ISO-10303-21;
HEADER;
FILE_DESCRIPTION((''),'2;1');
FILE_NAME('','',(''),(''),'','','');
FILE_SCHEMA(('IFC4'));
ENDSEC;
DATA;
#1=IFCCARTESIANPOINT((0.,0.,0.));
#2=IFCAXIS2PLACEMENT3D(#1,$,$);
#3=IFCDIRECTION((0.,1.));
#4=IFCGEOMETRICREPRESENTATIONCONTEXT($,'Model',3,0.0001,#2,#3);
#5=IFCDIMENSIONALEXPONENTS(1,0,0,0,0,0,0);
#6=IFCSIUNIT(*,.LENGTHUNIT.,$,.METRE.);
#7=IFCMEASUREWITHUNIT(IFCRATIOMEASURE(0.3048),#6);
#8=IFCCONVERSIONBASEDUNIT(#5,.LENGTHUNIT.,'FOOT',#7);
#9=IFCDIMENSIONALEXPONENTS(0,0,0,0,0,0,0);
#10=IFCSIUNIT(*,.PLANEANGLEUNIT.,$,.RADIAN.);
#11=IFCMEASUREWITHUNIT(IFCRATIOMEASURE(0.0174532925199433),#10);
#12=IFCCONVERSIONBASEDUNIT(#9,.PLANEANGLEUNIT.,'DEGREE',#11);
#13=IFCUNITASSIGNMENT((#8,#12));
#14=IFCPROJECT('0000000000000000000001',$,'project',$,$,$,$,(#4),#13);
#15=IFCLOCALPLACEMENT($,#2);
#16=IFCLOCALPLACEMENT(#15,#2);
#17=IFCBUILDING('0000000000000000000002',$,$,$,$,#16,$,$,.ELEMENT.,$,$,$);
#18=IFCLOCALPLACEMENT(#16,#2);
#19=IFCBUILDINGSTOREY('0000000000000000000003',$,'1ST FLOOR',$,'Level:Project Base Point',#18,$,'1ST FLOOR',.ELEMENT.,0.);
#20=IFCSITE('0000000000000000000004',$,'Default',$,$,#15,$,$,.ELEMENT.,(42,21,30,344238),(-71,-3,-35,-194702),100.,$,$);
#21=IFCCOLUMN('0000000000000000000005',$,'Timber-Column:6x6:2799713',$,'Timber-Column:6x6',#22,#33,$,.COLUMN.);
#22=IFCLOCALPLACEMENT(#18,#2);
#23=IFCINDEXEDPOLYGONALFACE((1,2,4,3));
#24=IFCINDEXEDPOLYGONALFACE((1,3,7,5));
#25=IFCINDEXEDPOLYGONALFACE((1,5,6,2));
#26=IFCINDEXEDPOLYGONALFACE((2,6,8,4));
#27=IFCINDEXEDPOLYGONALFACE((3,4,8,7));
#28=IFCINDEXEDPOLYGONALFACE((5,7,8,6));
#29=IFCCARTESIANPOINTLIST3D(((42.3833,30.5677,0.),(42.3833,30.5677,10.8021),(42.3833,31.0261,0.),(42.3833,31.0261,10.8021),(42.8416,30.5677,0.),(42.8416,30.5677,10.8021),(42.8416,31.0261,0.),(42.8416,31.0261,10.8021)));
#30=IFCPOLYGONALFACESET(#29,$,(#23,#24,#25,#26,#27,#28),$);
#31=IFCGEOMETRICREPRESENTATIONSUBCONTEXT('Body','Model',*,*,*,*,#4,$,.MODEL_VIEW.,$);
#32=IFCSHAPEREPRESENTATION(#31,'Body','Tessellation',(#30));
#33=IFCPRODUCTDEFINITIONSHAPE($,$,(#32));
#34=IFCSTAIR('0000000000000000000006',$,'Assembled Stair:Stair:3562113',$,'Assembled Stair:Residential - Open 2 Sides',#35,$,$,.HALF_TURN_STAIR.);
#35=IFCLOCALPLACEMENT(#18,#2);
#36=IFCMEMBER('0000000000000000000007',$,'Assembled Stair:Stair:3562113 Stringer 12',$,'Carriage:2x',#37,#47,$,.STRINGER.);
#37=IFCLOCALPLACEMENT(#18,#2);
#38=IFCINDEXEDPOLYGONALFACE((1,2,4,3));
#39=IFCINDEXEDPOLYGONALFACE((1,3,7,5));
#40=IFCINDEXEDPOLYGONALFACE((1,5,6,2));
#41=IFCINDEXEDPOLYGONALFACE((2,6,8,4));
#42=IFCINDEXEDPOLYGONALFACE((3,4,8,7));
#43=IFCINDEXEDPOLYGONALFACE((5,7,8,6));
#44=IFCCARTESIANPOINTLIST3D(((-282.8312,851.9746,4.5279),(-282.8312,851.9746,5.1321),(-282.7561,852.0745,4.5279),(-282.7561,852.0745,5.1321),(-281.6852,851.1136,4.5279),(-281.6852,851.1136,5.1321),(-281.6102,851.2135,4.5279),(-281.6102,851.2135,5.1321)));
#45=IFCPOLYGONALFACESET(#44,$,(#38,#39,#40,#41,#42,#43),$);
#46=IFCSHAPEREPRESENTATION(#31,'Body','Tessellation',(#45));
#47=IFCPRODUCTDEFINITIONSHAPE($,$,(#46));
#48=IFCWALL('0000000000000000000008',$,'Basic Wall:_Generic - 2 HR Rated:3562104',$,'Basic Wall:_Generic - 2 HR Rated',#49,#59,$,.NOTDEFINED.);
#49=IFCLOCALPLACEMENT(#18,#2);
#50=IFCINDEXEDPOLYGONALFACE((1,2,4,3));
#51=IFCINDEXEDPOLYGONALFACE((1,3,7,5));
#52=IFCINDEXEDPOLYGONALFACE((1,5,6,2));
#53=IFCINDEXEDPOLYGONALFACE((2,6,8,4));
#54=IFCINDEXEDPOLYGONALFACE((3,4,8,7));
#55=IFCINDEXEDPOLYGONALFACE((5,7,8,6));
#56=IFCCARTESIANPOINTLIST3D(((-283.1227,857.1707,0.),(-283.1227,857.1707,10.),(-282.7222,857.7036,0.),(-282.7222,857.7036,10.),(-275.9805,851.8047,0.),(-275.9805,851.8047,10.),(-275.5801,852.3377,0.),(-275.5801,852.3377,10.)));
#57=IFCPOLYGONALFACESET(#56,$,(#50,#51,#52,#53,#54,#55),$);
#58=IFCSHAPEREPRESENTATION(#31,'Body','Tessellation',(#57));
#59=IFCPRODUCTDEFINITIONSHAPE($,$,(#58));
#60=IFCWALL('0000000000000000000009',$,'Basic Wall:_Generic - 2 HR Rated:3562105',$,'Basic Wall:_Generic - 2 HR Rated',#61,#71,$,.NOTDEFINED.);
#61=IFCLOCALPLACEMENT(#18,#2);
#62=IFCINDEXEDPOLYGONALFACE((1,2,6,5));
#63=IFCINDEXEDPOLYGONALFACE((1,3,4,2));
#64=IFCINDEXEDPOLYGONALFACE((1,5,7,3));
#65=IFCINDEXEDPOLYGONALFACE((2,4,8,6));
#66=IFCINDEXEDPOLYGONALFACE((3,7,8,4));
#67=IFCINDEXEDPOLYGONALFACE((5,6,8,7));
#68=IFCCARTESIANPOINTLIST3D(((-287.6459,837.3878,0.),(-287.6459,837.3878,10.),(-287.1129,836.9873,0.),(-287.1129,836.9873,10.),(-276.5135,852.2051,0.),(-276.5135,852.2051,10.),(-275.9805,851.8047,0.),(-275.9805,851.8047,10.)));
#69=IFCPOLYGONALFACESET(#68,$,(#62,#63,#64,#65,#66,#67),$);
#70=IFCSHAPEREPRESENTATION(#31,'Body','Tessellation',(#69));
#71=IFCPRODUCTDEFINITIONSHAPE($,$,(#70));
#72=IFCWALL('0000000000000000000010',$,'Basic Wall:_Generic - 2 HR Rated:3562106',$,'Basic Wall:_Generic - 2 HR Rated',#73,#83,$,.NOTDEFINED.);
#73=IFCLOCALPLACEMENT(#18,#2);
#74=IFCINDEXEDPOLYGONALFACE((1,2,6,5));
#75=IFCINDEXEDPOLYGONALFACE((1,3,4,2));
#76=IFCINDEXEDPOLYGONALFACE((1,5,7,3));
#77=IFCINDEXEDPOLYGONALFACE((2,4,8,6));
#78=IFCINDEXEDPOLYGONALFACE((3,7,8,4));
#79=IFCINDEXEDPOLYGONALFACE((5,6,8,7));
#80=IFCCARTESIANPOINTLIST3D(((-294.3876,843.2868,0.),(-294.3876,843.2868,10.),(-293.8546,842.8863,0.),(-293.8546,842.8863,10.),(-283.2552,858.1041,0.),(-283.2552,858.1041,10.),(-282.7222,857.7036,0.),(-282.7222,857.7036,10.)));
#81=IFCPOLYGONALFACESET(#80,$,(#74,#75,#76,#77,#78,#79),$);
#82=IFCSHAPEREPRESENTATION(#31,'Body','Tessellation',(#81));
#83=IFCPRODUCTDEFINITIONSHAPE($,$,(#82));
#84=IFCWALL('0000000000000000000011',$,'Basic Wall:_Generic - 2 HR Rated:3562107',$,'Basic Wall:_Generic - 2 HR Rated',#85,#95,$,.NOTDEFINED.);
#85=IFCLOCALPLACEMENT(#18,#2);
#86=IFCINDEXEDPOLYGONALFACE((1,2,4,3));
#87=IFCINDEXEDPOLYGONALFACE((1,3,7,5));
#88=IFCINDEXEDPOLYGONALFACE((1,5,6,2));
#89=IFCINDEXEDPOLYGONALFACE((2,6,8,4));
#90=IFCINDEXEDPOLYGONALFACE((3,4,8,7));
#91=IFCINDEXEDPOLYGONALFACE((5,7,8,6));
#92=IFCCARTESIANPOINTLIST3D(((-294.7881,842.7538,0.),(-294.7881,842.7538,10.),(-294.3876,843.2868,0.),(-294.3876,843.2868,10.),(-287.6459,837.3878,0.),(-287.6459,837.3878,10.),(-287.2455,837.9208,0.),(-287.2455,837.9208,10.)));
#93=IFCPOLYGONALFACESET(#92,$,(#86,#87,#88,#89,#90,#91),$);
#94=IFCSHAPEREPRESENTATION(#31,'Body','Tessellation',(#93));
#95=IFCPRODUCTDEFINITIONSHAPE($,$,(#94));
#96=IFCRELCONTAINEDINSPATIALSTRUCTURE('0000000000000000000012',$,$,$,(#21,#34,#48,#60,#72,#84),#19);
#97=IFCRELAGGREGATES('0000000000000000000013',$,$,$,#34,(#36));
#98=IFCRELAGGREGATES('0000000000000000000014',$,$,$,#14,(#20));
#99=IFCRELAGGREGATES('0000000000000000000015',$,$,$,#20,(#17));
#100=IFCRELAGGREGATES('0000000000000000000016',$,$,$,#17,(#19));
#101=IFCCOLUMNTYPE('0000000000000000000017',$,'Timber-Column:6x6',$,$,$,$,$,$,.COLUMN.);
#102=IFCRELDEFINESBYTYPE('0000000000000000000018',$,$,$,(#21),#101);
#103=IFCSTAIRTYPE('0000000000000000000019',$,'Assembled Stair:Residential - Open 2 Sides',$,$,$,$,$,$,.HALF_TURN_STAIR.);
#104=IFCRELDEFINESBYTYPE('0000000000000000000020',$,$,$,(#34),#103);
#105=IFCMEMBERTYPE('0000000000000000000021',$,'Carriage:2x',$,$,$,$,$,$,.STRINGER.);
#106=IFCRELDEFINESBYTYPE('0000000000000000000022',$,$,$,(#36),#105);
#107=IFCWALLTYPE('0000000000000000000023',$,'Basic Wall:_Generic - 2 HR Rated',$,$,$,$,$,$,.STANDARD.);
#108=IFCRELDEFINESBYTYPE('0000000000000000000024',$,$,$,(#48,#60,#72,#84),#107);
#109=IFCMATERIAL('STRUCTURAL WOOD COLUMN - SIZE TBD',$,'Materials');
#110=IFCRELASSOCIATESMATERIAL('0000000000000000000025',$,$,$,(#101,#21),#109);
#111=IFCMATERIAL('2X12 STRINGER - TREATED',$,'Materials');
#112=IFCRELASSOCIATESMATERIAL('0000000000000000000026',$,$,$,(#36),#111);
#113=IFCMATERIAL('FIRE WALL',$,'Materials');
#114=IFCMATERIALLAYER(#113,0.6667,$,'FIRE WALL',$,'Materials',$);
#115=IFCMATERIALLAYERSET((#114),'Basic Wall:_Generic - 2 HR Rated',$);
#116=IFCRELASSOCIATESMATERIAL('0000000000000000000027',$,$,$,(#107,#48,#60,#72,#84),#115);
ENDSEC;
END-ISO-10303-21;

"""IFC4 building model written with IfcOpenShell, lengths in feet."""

from ifc_helpers import new_model, entity, si_unit, converted_unit, direction, frame, frame_2d, origin, origin_2d_with_axis, place, context, subcontext, project, spatial, rectangle, extrude, source, transform, mapped, material, layer, layer_set, layer_usage, material_profile, profile_set, profile_usage, type_object, type_shapes, element, aggregate, save


model = new_model("IFC4")

# Units and contexts
model_context = context("Model", 3, precision=0.0001, world=origin(), true_north=direction((0.0, 1.0)))
body_context = subcontext(model_context, "Body", "Model", "MODEL_VIEW")
ifc_project = project(units=[converted_unit("LENGTHUNIT", "FOOT", entity("IfcRatioMeasure", 0.3048), si_unit("LENGTHUNIT", "METRE"), dimensions=[1, 0, 0, 0, 0, 0, 0]), converted_unit("PLANEANGLEUNIT", "DEGREE", entity("IfcRatioMeasure", 0.0174532925199433), si_unit("PLANEANGLEUNIT", "RADIAN"), dimensions=[0, 0, 0, 0, 0, 0, 0])], contexts=[model_context])

# Site, building, storey
site_placement = place(None, origin())
site = spatial("IfcSite", under=ifc_project, at=site_placement, Name="Default", CompositionType="ELEMENT", RefLatitude=(42, 21, 30, 344238), RefLongitude=(-71, -3, -35, -194702), RefElevation=100.0)
building_placement = place(site_placement, origin())
building = spatial("IfcBuilding", under=site, at=building_placement, CompositionType="ELEMENT")
storey_placement = place(building_placement, origin())
storey = spatial("IfcBuildingStorey", under=building, at=storey_placement, Name="1ST FLOOR", ObjectType="Level:Project Base Point", LongName="1ST FLOOR", CompositionType="ELEMENT", Elevation=0.0)

# Column
ifc_material_1 = material(Name="STRUCTURAL WOOD COLUMN - SIZE TBD", Category="Materials")
ifc_material_profile = material_profile(ifc_material_1, rectangle(XDim=0.4583, YDim=0.4583, at=origin_2d_with_axis()), Name="6x6")
ifc_profile_set = profile_set([ifc_material_profile], Name="6x6")
ifc_profile_usage = profile_usage(ifc_profile_set)
column_type = type_object("IfcColumnType", Name="Timber-Column:6x6", PredefinedType="COLUMN", material=ifc_profile_set)
shared_shape_1 = source(origin(), body_context, "Body", "SweptSolid", [
    extrude(rectangle(XDim=0.4583, YDim=0.4583, at=frame_2d((0.0, 0.0), x_axis=(1.0, 0.0))), frame((0.0, 0.0, 0.0), z_axis=(0.0, 0.0, 1.0), x_axis=(0.0, -1.0, 0.0)), (0.0, 0.0, 1.0), 10.8021),
])
type_shapes(column_type, [shared_shape_1])
column_placement = place(storey_placement, frame((42.6125, 30.7969, 0.0)))
element("IfcColumn", 1, at=column_placement, inside=storey, type_object=column_type, material=ifc_profile_usage, Name="Timber-Column:6x6:2799713", ObjectType="Timber-Column:6x6", PredefinedType="COLUMN", context=body_context, shape_type="MappedRepresentation", body=[
    mapped(shared_shape_1, transform((0.0, 0.0, 0.0), scale=1.0)),
])

# Stair, member
stair_type = type_object("IfcStairType", Name="Assembled Stair:Residential - Open 2 Sides", PredefinedType="HALF_TURN_STAIR")
stair_placement = place(storey_placement, origin())
stair = element("IfcStair", 2, at=stair_placement, inside=storey, type_object=stair_type, Name="Assembled Stair:Stair:3562113", ObjectType="Assembled Stair:Residential - Open 2 Sides", PredefinedType="HALF_TURN_STAIR")
ifc_material_2 = material(Name="2X12 STRINGER - TREATED", Category="Materials")
member_type = type_object("IfcMemberType", Name="Carriage:2x", PredefinedType="STRINGER")
member_1_placement = place(stair_placement, frame((-282.8312, 851.1136, 4.5279)))
member_1 = element("IfcMember", 3, at=member_1_placement, type_object=member_type, material=ifc_material_2, Name="Assembled Stair:Stair:3562113 Stringer 12", ObjectType="Carriage:2x", PredefinedType="STRINGER", context=body_context, shape_type="SweptSolid", body=[
    extrude(rectangle(XDim=0.125, YDim=1.4333, at=frame_2d((0.0, 0.0), x_axis=(1.0, 0.0))), frame((0.6105, 0.4804, 0.0), z_axis=(0.0, 0.0, 1.0), x_axis=(-0.60067, -0.799497, 0.0)), (0.0, 0.0, 1.0), 0.6042),
])

# Walls
ifc_material_3 = material(Name="FIRE WALL", Category="Materials")
ifc_layer = layer(ifc_material_3, 0.6667, Name="FIRE WALL", Category="Materials")
ifc_layer_set = layer_set([ifc_layer], Name="Basic Wall:_Generic - 2 HR Rated")
ifc_layer_usage_1 = layer_usage(ifc_layer_set, "AXIS2", "NEGATIVE", 0.3333)
wall_type = type_object("IfcWallType", Name="Basic Wall:_Generic - 2 HR Rated", PredefinedType="STANDARD", material=ifc_layer_set)
wall_1_placement = place(storey_placement, frame((-282.9225, 857.4372, 0.0), z_axis=(0.0, 0.0, 1.0), x_axis=(0.799497, -0.60067, 0.0)))
element("IfcWall", 4, at=wall_1_placement, inside=storey, type_object=wall_type, material=ifc_layer_usage_1, Name="Basic Wall:_Generic - 2 HR Rated:3562104", ObjectType="Basic Wall:_Generic - 2 HR Rated", PredefinedType="NOTDEFINED", context=body_context, shape_type="SweptSolid", body=[
    extrude(rectangle(XDim=8.9333, YDim=0.6667, at=frame_2d((4.4667, 0.0), x_axis=(-1.0, 0.0))), origin(), (0.0, 0.0, 1.0), 10.0),
])
ifc_layer_usage_2 = layer_usage(ifc_layer_set, "AXIS2", "NEGATIVE", 0.3333)
wall_2_placement = place(storey_placement, frame((-276.247, 852.0049, 0.0), z_axis=(0.0, 0.0, 1.0), x_axis=(-0.60067, -0.799497, 0.0)))
element("IfcWall", 5, at=wall_2_placement, inside=storey, type_object=wall_type, material=ifc_layer_usage_2, Name="Basic Wall:_Generic - 2 HR Rated:3562105", ObjectType="Basic Wall:_Generic - 2 HR Rated", PredefinedType="NOTDEFINED", context=body_context, shape_type="SweptSolid", body=[
    extrude(rectangle(XDim=18.5333, YDim=0.6667, at=frame_2d((9.2667, 0.0), x_axis=(-1.0, 0.0))), origin(), (0.0, 0.0, 1.0), 10.0),
])
ifc_layer_usage_3 = layer_usage(ifc_layer_set, "AXIS2", "NEGATIVE", 0.3333)
wall_3_placement = place(storey_placement, frame((-294.1211, 843.0865, 0.0), z_axis=(0.0, 0.0, 1.0), x_axis=(0.60067, 0.799497, 0.0)))
element("IfcWall", 6, at=wall_3_placement, inside=storey, type_object=wall_type, material=ifc_layer_usage_3, Name="Basic Wall:_Generic - 2 HR Rated:3562106", ObjectType="Basic Wall:_Generic - 2 HR Rated", PredefinedType="NOTDEFINED", context=body_context, shape_type="SweptSolid", body=[
    extrude(rectangle(XDim=18.5333, YDim=0.6667, at=frame_2d((9.2667, 0.0), x_axis=(-1.0, 0.0))), origin(), (0.0, 0.0, 1.0), 10.0),
])
ifc_layer_usage_4 = layer_usage(ifc_layer_set, "AXIS2", "NEGATIVE", 0.3333)
wall_4_placement = place(storey_placement, frame((-287.4457, 837.6543, 0.0), z_axis=(0.0, 0.0, 1.0), x_axis=(-0.799497, 0.60067, 0.0)))
element("IfcWall", 7, at=wall_4_placement, inside=storey, type_object=wall_type, material=ifc_layer_usage_4, Name="Basic Wall:_Generic - 2 HR Rated:3562107", ObjectType="Basic Wall:_Generic - 2 HR Rated", PredefinedType="NOTDEFINED", context=body_context, shape_type="SweptSolid", body=[
    extrude(rectangle(XDim=8.9333, YDim=0.6667, at=frame_2d((4.4667, 0.0), x_axis=(-1.0, 0.0))), origin(), (0.0, 0.0, 1.0), 10.0),
])

aggregate(stair, [member_1])

save(model, "model.ifc")
